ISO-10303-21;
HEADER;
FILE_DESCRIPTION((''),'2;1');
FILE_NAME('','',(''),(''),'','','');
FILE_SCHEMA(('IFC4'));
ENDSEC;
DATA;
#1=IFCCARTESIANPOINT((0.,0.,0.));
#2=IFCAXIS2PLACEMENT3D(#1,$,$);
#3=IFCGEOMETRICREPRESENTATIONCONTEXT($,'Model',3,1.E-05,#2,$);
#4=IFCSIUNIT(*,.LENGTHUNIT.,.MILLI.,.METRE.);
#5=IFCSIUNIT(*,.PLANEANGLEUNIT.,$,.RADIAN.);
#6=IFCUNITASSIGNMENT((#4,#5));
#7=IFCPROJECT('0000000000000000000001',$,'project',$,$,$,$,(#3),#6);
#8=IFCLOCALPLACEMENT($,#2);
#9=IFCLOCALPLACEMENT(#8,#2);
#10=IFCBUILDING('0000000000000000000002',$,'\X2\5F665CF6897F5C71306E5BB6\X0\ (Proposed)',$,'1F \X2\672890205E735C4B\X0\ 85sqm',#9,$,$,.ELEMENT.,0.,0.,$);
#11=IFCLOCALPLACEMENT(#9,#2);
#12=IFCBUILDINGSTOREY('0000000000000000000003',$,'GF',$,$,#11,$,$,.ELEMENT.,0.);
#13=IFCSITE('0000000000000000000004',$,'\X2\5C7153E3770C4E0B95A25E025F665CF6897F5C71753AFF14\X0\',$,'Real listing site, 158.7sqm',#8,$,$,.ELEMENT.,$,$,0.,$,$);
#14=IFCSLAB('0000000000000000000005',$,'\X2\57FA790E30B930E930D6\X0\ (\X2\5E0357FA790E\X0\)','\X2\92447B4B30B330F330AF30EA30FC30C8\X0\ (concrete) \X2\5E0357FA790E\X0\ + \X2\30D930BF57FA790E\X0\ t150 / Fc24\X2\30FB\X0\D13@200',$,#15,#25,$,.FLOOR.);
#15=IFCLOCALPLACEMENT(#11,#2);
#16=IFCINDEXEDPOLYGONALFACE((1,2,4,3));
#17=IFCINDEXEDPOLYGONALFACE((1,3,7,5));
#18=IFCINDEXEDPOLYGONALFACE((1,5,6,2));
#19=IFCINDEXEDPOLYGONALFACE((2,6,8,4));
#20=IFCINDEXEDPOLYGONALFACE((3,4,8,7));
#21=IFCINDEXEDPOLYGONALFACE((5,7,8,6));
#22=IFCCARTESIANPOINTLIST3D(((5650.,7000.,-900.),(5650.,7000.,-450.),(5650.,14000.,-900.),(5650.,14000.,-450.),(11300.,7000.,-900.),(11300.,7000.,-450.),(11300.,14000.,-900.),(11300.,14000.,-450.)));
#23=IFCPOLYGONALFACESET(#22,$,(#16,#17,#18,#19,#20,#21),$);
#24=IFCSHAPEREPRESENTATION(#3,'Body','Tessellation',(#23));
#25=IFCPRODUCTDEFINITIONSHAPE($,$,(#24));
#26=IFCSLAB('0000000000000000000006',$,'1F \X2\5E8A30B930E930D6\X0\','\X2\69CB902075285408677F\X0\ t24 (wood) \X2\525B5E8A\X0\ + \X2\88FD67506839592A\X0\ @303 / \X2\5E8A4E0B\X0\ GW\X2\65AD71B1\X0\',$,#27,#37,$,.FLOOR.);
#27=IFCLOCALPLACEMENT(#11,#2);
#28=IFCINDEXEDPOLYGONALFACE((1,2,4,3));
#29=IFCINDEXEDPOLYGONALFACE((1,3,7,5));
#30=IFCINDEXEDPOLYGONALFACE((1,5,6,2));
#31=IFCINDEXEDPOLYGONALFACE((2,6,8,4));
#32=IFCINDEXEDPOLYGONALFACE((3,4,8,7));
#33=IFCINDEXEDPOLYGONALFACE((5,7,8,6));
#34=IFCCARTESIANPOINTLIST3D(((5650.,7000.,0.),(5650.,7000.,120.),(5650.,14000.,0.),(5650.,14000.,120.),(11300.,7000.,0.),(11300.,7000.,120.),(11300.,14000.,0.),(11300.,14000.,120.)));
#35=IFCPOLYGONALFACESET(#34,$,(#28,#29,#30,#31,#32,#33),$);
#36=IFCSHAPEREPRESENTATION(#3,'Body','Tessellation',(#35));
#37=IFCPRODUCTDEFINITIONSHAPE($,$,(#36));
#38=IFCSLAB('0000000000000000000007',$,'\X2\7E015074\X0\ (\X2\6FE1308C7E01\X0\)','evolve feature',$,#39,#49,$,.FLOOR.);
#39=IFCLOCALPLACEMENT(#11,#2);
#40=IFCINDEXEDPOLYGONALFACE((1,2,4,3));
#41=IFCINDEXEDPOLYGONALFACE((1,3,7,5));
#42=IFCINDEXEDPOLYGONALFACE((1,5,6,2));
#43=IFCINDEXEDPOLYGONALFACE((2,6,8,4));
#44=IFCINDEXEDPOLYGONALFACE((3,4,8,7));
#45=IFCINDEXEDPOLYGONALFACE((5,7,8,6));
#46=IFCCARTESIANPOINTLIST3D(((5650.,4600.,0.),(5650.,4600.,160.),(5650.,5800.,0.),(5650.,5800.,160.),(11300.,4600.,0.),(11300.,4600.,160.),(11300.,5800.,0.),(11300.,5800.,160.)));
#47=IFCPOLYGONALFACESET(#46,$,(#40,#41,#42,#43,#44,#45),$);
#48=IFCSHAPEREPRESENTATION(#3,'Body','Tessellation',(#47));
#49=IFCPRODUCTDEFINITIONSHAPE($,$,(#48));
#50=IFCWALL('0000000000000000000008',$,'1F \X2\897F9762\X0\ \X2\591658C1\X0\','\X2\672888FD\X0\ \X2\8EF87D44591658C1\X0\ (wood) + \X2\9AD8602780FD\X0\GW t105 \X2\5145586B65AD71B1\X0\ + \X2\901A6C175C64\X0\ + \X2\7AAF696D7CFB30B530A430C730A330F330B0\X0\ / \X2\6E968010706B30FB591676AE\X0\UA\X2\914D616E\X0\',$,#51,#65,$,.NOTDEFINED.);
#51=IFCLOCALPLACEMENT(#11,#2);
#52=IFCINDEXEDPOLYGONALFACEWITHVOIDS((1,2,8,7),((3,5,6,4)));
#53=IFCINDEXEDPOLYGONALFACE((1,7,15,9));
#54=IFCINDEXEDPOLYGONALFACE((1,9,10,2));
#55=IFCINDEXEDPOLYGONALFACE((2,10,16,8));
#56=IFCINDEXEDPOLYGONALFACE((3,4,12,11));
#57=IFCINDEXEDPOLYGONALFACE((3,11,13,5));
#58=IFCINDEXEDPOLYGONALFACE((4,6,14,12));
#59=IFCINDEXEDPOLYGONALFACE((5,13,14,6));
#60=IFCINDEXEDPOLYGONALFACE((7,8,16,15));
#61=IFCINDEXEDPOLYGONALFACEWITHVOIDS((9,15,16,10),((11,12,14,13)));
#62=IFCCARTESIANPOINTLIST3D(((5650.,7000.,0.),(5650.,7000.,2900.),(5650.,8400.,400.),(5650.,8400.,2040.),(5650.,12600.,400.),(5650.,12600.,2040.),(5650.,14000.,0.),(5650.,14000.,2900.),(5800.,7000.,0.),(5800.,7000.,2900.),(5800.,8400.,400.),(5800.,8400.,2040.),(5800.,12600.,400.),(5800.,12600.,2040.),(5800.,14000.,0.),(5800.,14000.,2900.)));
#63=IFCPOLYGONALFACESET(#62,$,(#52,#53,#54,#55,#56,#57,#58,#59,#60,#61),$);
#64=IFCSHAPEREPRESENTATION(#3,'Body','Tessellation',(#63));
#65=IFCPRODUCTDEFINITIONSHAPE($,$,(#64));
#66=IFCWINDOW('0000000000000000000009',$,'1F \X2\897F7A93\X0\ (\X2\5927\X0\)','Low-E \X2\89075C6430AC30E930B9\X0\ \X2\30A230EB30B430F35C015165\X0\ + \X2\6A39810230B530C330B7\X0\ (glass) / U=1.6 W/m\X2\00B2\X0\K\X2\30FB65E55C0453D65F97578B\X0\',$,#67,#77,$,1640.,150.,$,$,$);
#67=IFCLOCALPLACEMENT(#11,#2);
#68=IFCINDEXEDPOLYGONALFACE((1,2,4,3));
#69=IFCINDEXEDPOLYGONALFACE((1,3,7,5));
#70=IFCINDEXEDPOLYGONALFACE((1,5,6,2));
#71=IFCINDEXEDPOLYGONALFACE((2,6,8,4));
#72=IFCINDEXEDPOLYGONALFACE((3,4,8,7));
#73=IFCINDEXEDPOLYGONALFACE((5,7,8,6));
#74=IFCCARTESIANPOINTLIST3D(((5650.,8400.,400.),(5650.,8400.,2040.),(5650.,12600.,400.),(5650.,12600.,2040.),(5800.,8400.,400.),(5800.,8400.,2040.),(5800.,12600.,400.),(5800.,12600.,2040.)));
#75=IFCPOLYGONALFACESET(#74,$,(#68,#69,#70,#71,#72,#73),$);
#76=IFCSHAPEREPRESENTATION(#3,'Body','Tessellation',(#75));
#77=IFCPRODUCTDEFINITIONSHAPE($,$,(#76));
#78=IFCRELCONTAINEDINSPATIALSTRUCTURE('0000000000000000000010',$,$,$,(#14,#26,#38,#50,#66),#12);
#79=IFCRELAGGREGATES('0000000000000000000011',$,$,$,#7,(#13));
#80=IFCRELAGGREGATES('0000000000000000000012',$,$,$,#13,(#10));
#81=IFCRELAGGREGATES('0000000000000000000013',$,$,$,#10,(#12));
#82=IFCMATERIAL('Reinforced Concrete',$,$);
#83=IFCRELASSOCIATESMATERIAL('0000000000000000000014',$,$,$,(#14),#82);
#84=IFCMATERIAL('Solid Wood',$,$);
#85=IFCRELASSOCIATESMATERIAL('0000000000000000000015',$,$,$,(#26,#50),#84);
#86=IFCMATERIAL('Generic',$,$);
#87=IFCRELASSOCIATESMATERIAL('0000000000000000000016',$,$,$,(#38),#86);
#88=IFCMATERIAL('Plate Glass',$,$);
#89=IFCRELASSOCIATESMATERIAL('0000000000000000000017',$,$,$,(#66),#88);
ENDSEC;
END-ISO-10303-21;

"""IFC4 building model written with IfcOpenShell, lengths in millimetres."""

from ifc_helpers import new_model, si_unit, frame, frame_2d, origin, place, context, project, spatial, rectangle, extrude, material, element, fill, save


model = new_model("IFC4")

# Units and contexts
model_context = context("Model", 3, precision=1e-05, world=origin())
ifc_project = project(units=[si_unit("LENGTHUNIT", "METRE", prefix="MILLI"), si_unit("PLANEANGLEUNIT", "RADIAN")], contexts=[model_context])

# Site, building, storey
site_placement = place(None, origin())
site = spatial("IfcSite", under=ifc_project, at=site_placement, Name="山口県下関市彦島西山町４", ObjectType="Real listing site, 158.7sqm", CompositionType="ELEMENT", RefElevation=0.0)
building_placement = place(site_placement, origin())
building = spatial("IfcBuilding", under=site, at=building_placement, Name="彦島西山の家 (Proposed)", ObjectType="1F 木造平屋 85sqm", CompositionType="ELEMENT", ElevationOfRefHeight=0.0, ElevationOfTerrain=0.0)
storey_placement = place(building_placement, origin())
storey = spatial("IfcBuildingStorey", under=building, at=storey_placement, Name="GF", CompositionType="ELEMENT", Elevation=0.0)

# Slabs
ifc_material_1 = material(Name="Reinforced Concrete")
slab_1_placement = place(storey_placement, frame((2825.0, 3500.0, -450.0)))
element("IfcSlab", 1, at=slab_1_placement, inside=storey, material=ifc_material_1, Name="基礎スラブ (布基礎)", Description="鉄筋コンクリート (concrete) 布基礎 + ベタ基礎 t150 / Fc24・D13@200", PredefinedType="FLOOR", context=model_context, shape_type="SweptSolid", body=[
    extrude(rectangle(XDim=5650.0, YDim=7000.0, at=frame_2d((2825.0, 3500.0))), frame((2825.0, 3500.0, -450.0)), (0.0, 0.0, 1.0), 450.0),
])
ifc_material_2 = material(Name="Solid Wood")
slab_2_placement = place(storey_placement, frame((2825.0, 3500.0, 0.0)))
element("IfcSlab", 2, at=slab_2_placement, inside=storey, material=ifc_material_2, Name="1F 床スラブ", Description="構造用合板 t24 (wood) 剛床 + 製材根太 @303 / 床下 GW断熱", PredefinedType="FLOOR", context=model_context, shape_type="SweptSolid", body=[
    extrude(rectangle(XDim=5650.0, YDim=7000.0, at=frame_2d((2825.0, 3500.0))), frame((2825.0, 3500.0, 0.0)), (0.0, 0.0, 1.0), 120.0),
])
ifc_material_3 = material(Name="Generic")
slab_3_placement = place(storey_placement, frame((2825.0, 2300.0, 0.0)))
element("IfcSlab", 3, at=slab_3_placement, inside=storey, material=ifc_material_3, Name="縁側 (濡れ縁)", Description="evolve feature", PredefinedType="FLOOR", context=model_context, shape_type="SweptSolid", body=[
    extrude(rectangle(XDim=5650.0, YDim=1200.0, at=frame_2d((2825.0, 600.0))), frame((2825.0, 2300.0, 0.0)), (0.0, 0.0, 1.0), 160.0),
])

# Shared definitions
ifc_material_4 = material(Name="Plate Glass")

# Wall, opening, window
wall_1_placement = place(storey_placement, frame((2825.0, 3500.0, 0.0)))
wall_1 = element("IfcWall", 4, at=wall_1_placement, inside=storey, material=ifc_material_2, Name="1F 西面 外壁", Description="木製 軸組外壁 (wood) + 高性能GW t105 充填断熱 + 通気層 + 窯業系サイディング / 準耐火・外皮UA配慮", PredefinedType="NOTDEFINED", context=model_context, shape_type="SweptSolid", body=[
    extrude(rectangle(XDim=150.0, YDim=7000.0, at=frame_2d((75.0, 3500.0))), frame((2825.0, 3500.0, 0.0)), (0.0, 0.0, 1.0), 2900.0),
])
opening_1_placement = place(storey_placement, frame((2825.0, 4200.0, 200.0)))
opening_1 = element("IfcOpeningElement", 5, at=opening_1_placement, cuts=wall_1, PredefinedType="NOTDEFINED", context=model_context, shape_type="SweptSolid", body=[
    extrude(rectangle(XDim=150.0, YDim=4200.0, at=frame_2d((75.0, 2100.0))), frame((2825.0, 4200.0, 200.0)), (0.0, 0.0, 1.0), 1640.0),
])
window_1_placement = place(storey_placement, frame((2825.0, 4200.0, 200.0)))
window_1 = element("IfcWindow", 6, at=window_1_placement, inside=storey, material=ifc_material_4, Name="1F 西窓 (大)", Description="Low-E 複層ガラス アルゴン封入 + 樹脂サッシ (glass) / U=1.6 W/m²K・日射取得型", OverallHeight=1640.0, OverallWidth=150.0, context=model_context, shape_type="SweptSolid", body=[
    extrude(rectangle(XDim=150.0, YDim=4200.0, at=frame_2d((75.0, 2100.0))), frame((2825.0, 4200.0, 200.0)), (0.0, 0.0, 1.0), 1640.0),
])
fill(opening_1, window_1)

save(model, "model.ifc")
